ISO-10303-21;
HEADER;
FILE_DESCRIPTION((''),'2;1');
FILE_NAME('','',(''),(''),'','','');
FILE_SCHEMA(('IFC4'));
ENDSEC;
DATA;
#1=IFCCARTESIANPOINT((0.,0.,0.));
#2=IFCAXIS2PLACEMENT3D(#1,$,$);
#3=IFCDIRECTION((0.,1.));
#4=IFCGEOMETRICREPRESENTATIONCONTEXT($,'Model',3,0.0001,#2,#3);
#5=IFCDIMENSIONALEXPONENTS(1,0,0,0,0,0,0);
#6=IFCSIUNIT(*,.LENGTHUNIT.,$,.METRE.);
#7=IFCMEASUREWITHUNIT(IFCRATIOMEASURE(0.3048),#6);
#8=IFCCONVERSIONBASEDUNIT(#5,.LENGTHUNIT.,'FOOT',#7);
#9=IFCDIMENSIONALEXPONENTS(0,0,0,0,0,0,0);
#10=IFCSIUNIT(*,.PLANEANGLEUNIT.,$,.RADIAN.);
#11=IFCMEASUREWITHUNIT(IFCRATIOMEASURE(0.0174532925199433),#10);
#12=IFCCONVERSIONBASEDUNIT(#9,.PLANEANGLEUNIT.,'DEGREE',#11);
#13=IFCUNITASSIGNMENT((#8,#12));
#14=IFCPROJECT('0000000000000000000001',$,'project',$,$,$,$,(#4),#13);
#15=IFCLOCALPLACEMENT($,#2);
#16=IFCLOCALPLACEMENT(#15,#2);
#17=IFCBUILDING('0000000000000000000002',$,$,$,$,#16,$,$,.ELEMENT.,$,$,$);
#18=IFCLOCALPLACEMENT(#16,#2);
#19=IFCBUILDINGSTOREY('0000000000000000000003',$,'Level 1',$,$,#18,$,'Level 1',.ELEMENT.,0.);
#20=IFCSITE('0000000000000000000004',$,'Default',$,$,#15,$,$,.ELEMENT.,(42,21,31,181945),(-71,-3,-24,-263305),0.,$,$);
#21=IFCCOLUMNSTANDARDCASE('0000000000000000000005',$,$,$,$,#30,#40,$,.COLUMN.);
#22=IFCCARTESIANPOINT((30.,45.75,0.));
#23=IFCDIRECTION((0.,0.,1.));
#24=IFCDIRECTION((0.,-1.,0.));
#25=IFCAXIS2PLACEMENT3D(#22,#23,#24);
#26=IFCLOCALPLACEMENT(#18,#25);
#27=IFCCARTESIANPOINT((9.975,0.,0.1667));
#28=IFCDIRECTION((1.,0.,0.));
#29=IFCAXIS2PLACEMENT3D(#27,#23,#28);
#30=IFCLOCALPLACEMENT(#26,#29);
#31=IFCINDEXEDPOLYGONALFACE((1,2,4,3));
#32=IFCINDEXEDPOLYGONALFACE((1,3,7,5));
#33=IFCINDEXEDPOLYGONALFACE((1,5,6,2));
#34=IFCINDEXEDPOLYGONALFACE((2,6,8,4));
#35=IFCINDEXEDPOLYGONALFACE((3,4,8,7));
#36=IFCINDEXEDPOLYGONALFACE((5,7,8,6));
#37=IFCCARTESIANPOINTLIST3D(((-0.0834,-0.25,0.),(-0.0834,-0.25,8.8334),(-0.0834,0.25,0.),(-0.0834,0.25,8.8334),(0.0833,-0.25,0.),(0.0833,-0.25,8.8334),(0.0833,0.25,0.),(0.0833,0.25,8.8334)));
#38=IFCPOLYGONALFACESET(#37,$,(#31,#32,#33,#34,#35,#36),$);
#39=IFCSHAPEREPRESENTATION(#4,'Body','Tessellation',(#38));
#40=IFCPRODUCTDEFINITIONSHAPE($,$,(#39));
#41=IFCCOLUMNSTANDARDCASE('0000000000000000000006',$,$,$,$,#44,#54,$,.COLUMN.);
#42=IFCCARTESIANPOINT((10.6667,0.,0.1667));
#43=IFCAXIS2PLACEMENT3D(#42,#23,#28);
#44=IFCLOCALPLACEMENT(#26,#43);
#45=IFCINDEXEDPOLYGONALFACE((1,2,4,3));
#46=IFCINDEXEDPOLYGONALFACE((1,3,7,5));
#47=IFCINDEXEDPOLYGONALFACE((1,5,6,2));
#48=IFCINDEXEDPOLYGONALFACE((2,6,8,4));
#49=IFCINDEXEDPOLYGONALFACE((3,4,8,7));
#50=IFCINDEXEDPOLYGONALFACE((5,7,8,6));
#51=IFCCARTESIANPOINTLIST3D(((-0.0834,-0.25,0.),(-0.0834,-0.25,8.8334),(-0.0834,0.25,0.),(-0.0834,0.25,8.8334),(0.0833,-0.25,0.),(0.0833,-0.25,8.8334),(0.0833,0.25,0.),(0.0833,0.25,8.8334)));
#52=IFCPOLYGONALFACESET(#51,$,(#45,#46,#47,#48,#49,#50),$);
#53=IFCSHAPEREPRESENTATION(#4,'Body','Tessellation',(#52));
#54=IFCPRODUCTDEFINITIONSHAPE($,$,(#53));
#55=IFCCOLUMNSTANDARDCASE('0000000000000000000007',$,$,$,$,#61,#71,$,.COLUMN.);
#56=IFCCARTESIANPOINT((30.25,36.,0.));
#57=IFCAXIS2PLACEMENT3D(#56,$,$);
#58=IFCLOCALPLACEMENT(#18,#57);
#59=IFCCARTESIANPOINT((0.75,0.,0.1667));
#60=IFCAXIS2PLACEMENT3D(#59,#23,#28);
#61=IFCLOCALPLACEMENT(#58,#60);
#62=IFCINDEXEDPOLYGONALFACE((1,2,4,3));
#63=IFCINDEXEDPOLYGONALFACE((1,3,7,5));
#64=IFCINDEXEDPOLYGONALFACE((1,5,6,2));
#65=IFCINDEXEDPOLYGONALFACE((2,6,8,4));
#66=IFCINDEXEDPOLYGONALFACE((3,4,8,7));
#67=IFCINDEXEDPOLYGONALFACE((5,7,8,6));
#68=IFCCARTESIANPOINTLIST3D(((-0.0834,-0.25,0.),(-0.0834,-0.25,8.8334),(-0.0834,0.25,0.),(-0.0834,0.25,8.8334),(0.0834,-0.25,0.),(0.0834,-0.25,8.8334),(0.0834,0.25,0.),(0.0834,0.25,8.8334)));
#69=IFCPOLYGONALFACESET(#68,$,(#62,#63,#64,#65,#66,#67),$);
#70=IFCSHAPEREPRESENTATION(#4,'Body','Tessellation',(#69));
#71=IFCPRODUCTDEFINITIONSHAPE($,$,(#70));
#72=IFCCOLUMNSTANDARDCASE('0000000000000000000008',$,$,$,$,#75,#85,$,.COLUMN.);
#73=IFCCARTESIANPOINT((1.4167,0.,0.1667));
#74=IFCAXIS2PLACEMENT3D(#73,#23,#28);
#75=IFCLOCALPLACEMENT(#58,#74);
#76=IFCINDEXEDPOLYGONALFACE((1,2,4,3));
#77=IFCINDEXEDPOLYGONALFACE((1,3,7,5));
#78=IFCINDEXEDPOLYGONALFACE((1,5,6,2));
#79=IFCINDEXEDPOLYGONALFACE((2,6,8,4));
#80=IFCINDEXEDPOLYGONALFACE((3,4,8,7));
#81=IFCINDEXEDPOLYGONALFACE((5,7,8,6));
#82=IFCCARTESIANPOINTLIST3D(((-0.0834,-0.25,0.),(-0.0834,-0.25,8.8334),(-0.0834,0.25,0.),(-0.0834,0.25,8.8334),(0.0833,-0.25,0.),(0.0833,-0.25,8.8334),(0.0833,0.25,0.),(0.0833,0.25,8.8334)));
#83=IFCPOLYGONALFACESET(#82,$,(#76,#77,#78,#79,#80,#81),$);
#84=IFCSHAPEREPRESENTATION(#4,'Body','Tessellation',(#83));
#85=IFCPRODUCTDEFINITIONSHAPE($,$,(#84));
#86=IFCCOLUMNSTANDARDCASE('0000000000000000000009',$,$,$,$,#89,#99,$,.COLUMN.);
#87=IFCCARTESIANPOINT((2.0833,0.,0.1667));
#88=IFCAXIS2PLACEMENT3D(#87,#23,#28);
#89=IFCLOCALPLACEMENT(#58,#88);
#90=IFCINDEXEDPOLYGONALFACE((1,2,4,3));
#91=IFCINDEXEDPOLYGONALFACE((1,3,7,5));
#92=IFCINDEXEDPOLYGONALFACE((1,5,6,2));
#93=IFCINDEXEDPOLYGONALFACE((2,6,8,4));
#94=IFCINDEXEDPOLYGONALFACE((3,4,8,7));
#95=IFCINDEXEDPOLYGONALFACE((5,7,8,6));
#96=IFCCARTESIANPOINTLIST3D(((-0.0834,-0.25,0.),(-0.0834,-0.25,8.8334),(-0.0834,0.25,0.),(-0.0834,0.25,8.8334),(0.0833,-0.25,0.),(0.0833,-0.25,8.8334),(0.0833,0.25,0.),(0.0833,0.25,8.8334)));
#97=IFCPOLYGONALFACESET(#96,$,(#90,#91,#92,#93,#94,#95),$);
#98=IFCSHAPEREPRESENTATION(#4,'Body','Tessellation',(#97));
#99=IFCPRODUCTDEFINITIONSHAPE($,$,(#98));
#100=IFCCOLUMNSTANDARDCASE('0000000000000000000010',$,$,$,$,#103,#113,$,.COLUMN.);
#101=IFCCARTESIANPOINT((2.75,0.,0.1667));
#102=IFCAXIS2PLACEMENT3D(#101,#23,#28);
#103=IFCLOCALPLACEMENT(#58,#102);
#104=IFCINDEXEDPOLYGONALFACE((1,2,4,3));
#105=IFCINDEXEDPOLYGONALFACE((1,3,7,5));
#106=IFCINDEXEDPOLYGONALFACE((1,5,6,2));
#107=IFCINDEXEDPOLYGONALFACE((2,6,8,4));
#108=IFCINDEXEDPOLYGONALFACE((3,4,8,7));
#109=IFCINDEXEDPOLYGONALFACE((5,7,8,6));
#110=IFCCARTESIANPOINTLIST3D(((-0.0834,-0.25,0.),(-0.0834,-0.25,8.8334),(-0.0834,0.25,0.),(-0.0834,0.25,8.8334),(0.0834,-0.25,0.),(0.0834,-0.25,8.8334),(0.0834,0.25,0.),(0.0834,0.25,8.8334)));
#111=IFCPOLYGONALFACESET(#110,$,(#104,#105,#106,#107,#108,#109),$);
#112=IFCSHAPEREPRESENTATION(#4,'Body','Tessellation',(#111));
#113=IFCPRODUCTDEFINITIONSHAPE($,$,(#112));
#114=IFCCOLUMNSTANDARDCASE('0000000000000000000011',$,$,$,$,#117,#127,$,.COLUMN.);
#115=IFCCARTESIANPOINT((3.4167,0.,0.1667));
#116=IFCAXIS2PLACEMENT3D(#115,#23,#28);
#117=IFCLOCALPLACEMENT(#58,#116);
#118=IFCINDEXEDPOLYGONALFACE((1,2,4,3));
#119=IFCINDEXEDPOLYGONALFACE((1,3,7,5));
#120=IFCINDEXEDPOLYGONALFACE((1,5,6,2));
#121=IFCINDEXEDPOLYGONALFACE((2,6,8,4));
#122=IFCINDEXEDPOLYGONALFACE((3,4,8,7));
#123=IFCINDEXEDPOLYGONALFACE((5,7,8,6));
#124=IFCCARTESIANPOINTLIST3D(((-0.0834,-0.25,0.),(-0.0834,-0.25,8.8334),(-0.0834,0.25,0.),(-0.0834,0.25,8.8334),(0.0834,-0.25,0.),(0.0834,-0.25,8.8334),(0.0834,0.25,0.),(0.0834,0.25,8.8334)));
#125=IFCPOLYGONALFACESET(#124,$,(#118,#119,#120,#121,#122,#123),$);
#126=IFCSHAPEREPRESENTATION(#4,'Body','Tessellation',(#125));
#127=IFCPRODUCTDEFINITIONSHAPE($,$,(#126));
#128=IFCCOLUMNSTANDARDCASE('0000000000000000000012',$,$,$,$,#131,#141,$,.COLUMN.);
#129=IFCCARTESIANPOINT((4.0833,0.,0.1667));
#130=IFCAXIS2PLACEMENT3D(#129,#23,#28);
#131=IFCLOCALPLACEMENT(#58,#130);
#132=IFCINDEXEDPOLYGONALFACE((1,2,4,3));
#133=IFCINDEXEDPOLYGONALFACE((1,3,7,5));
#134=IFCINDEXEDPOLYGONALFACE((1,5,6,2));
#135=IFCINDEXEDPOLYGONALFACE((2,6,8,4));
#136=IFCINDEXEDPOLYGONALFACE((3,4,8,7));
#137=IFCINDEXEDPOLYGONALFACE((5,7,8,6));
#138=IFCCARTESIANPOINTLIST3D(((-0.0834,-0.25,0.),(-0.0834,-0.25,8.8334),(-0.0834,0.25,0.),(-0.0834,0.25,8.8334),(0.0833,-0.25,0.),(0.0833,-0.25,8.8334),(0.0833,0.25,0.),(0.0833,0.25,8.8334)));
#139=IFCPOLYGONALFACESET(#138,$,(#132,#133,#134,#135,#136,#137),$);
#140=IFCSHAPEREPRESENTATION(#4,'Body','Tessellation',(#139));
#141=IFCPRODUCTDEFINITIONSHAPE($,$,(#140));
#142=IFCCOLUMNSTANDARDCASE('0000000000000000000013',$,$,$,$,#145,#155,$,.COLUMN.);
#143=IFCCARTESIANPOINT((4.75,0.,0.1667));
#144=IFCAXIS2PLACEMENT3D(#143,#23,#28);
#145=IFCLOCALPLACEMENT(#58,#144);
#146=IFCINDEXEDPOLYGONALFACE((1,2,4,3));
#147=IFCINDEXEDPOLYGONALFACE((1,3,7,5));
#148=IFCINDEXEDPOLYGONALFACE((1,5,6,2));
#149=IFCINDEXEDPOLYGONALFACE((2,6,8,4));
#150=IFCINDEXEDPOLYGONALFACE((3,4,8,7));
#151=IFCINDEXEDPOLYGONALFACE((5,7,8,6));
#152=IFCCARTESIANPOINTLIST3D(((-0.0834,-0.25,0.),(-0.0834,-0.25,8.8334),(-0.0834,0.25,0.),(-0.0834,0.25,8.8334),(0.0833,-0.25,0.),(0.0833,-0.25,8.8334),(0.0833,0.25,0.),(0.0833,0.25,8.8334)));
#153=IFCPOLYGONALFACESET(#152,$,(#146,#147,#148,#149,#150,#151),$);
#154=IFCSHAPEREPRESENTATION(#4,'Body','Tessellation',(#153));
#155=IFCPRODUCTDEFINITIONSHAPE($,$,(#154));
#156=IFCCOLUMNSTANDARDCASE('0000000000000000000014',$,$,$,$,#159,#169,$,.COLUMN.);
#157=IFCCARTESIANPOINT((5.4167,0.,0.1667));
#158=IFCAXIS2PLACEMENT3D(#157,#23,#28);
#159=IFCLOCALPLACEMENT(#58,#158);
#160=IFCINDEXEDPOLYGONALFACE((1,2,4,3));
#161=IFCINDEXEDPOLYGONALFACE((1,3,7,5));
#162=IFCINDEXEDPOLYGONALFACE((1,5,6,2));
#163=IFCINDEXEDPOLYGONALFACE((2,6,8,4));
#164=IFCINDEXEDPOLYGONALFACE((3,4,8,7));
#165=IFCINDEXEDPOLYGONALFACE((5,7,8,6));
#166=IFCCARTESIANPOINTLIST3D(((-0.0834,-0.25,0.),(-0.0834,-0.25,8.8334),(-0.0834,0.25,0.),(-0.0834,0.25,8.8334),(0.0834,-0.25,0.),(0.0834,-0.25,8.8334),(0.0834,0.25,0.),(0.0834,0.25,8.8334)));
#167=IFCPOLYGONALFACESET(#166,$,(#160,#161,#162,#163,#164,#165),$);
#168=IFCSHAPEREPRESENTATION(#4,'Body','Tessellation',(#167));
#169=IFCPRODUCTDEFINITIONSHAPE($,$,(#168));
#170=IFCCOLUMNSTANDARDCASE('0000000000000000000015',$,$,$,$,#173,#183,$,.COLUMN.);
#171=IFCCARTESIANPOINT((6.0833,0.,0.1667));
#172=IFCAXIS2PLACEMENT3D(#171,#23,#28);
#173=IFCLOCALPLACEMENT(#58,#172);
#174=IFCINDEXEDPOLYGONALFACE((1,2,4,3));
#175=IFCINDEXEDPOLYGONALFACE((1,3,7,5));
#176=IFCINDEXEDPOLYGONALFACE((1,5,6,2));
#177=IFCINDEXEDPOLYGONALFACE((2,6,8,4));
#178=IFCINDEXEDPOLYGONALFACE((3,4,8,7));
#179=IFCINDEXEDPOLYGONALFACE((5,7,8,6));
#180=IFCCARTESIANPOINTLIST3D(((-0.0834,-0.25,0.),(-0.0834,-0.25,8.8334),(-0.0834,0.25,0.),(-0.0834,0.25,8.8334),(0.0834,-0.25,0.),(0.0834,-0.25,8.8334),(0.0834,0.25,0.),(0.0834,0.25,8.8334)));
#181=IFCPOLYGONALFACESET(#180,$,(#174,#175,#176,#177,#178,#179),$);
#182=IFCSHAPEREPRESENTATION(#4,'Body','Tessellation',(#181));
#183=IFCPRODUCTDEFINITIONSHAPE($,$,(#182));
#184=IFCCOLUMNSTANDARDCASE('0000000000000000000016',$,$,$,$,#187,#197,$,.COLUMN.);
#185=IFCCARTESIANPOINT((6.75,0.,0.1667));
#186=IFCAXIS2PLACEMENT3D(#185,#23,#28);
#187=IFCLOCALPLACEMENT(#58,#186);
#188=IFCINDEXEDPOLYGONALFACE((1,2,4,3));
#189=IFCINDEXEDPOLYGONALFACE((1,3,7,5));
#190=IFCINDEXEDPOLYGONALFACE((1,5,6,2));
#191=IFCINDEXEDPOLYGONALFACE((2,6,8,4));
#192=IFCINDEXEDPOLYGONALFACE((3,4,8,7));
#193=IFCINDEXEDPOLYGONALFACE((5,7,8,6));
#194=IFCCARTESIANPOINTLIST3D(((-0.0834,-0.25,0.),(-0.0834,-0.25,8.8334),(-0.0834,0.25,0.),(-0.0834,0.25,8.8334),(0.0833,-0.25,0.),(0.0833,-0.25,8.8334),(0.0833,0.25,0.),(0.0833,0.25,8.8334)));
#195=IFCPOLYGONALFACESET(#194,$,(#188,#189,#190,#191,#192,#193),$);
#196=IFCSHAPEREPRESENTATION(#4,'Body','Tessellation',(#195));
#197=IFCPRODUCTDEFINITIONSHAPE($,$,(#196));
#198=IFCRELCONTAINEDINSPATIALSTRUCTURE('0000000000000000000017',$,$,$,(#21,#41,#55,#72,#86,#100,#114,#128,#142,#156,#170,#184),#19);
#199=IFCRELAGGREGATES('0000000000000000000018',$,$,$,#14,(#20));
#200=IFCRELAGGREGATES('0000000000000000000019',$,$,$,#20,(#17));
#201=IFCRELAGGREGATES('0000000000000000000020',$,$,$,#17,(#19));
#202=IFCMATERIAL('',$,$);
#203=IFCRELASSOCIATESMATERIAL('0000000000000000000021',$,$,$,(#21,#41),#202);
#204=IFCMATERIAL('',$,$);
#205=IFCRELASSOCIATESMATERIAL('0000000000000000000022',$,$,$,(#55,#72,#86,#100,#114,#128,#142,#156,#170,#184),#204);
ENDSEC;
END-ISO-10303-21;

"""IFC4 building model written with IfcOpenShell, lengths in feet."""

from ifc_helpers import new_model, entity, si_unit, converted_unit, direction, frame, origin, place, context, project, spatial, rectangle, extrude, material, element, save


model = new_model("IFC4")

# Units and contexts
model_context = context("Model", 3, precision=0.0001, world=origin(), true_north=direction((0.0, 1.0)))
ifc_project = project(units=[converted_unit("LENGTHUNIT", "FOOT", entity("IfcRatioMeasure", 0.3048), si_unit("LENGTHUNIT", "METRE"), dimensions=[1, 0, 0, 0, 0, 0, 0]), converted_unit("PLANEANGLEUNIT", "DEGREE", entity("IfcRatioMeasure", 0.0174532925199433), si_unit("PLANEANGLEUNIT", "RADIAN"), dimensions=[0, 0, 0, 0, 0, 0, 0])], contexts=[model_context])

# Site, building, storey
site_placement = place(None, origin())
site = spatial("IfcSite", under=ifc_project, at=site_placement, Name="Default", CompositionType="ELEMENT", RefLatitude=(42, 21, 31, 181945), RefLongitude=(-71, -3, -24, -263305), RefElevation=0.0)
building_placement = place(site_placement, origin())
building = spatial("IfcBuilding", under=site, at=building_placement, CompositionType="ELEMENT")
storey_placement = place(building_placement, origin())
storey = spatial("IfcBuildingStorey", under=building, at=storey_placement, Name="Level 1", LongName="Level 1", CompositionType="ELEMENT", Elevation=0.0)

# Columns
ifc_material_1 = material(Name="")
placement_1 = place(storey_placement, frame((30.0, 45.75, 0.0), z_axis=(0.0, 0.0, 1.0), x_axis=(0.0, -1.0, 0.0)))
for number, where, z_axis, x_axis in (
    (1, (9.975, 0.0, 0.1667), (0.0, 0.0, 1.0), (1.0, 0.0, 0.0)),
    (2, (10.6667, 0.0, 0.1667), (0.0, 0.0, 1.0), (1.0, 0.0, 0.0)),
):
    element("IfcColumnStandardCase", number, at=place(placement_1, frame(where, z_axis=z_axis, x_axis=x_axis)), inside=storey, material=ifc_material_1, PredefinedType="COLUMN", context=model_context, shape_type="SweptSolid", body=[
        extrude(rectangle(XDim=0.1667, YDim=0.5), origin(), (0.0, 0.0, 1.0), 8.8334),
    ])
ifc_material_2 = material(Name="")
placement_2 = place(storey_placement, frame((30.25, 36.0, 0.0)))
for number, where, z_axis, x_axis in (
    (3, (0.75, 0.0, 0.1667), (0.0, 0.0, 1.0), (1.0, 0.0, 0.0)),
    (4, (1.4167, 0.0, 0.1667), (0.0, 0.0, 1.0), (1.0, 0.0, 0.0)),
    (5, (2.0833, 0.0, 0.1667), (0.0, 0.0, 1.0), (1.0, 0.0, 0.0)),
    (6, (2.75, 0.0, 0.1667), (0.0, 0.0, 1.0), (1.0, 0.0, 0.0)),
    (7, (3.4167, 0.0, 0.1667), (0.0, 0.0, 1.0), (1.0, 0.0, 0.0)),
    (8, (4.0833, 0.0, 0.1667), (0.0, 0.0, 1.0), (1.0, 0.0, 0.0)),
    (9, (4.75, 0.0, 0.1667), (0.0, 0.0, 1.0), (1.0, 0.0, 0.0)),
    (10, (5.4167, 0.0, 0.1667), (0.0, 0.0, 1.0), (1.0, 0.0, 0.0)),
    (11, (6.0833, 0.0, 0.1667), (0.0, 0.0, 1.0), (1.0, 0.0, 0.0)),
    (12, (6.75, 0.0, 0.1667), (0.0, 0.0, 1.0), (1.0, 0.0, 0.0)),
):
    element("IfcColumnStandardCase", number, at=place(placement_2, frame(where, z_axis=z_axis, x_axis=x_axis)), inside=storey, material=ifc_material_2, PredefinedType="COLUMN", context=model_context, shape_type="SweptSolid", body=[
        extrude(rectangle(XDim=0.1667, YDim=0.5), origin(), (0.0, 0.0, 1.0), 8.8334),
    ])

save(model, "model.ifc")
